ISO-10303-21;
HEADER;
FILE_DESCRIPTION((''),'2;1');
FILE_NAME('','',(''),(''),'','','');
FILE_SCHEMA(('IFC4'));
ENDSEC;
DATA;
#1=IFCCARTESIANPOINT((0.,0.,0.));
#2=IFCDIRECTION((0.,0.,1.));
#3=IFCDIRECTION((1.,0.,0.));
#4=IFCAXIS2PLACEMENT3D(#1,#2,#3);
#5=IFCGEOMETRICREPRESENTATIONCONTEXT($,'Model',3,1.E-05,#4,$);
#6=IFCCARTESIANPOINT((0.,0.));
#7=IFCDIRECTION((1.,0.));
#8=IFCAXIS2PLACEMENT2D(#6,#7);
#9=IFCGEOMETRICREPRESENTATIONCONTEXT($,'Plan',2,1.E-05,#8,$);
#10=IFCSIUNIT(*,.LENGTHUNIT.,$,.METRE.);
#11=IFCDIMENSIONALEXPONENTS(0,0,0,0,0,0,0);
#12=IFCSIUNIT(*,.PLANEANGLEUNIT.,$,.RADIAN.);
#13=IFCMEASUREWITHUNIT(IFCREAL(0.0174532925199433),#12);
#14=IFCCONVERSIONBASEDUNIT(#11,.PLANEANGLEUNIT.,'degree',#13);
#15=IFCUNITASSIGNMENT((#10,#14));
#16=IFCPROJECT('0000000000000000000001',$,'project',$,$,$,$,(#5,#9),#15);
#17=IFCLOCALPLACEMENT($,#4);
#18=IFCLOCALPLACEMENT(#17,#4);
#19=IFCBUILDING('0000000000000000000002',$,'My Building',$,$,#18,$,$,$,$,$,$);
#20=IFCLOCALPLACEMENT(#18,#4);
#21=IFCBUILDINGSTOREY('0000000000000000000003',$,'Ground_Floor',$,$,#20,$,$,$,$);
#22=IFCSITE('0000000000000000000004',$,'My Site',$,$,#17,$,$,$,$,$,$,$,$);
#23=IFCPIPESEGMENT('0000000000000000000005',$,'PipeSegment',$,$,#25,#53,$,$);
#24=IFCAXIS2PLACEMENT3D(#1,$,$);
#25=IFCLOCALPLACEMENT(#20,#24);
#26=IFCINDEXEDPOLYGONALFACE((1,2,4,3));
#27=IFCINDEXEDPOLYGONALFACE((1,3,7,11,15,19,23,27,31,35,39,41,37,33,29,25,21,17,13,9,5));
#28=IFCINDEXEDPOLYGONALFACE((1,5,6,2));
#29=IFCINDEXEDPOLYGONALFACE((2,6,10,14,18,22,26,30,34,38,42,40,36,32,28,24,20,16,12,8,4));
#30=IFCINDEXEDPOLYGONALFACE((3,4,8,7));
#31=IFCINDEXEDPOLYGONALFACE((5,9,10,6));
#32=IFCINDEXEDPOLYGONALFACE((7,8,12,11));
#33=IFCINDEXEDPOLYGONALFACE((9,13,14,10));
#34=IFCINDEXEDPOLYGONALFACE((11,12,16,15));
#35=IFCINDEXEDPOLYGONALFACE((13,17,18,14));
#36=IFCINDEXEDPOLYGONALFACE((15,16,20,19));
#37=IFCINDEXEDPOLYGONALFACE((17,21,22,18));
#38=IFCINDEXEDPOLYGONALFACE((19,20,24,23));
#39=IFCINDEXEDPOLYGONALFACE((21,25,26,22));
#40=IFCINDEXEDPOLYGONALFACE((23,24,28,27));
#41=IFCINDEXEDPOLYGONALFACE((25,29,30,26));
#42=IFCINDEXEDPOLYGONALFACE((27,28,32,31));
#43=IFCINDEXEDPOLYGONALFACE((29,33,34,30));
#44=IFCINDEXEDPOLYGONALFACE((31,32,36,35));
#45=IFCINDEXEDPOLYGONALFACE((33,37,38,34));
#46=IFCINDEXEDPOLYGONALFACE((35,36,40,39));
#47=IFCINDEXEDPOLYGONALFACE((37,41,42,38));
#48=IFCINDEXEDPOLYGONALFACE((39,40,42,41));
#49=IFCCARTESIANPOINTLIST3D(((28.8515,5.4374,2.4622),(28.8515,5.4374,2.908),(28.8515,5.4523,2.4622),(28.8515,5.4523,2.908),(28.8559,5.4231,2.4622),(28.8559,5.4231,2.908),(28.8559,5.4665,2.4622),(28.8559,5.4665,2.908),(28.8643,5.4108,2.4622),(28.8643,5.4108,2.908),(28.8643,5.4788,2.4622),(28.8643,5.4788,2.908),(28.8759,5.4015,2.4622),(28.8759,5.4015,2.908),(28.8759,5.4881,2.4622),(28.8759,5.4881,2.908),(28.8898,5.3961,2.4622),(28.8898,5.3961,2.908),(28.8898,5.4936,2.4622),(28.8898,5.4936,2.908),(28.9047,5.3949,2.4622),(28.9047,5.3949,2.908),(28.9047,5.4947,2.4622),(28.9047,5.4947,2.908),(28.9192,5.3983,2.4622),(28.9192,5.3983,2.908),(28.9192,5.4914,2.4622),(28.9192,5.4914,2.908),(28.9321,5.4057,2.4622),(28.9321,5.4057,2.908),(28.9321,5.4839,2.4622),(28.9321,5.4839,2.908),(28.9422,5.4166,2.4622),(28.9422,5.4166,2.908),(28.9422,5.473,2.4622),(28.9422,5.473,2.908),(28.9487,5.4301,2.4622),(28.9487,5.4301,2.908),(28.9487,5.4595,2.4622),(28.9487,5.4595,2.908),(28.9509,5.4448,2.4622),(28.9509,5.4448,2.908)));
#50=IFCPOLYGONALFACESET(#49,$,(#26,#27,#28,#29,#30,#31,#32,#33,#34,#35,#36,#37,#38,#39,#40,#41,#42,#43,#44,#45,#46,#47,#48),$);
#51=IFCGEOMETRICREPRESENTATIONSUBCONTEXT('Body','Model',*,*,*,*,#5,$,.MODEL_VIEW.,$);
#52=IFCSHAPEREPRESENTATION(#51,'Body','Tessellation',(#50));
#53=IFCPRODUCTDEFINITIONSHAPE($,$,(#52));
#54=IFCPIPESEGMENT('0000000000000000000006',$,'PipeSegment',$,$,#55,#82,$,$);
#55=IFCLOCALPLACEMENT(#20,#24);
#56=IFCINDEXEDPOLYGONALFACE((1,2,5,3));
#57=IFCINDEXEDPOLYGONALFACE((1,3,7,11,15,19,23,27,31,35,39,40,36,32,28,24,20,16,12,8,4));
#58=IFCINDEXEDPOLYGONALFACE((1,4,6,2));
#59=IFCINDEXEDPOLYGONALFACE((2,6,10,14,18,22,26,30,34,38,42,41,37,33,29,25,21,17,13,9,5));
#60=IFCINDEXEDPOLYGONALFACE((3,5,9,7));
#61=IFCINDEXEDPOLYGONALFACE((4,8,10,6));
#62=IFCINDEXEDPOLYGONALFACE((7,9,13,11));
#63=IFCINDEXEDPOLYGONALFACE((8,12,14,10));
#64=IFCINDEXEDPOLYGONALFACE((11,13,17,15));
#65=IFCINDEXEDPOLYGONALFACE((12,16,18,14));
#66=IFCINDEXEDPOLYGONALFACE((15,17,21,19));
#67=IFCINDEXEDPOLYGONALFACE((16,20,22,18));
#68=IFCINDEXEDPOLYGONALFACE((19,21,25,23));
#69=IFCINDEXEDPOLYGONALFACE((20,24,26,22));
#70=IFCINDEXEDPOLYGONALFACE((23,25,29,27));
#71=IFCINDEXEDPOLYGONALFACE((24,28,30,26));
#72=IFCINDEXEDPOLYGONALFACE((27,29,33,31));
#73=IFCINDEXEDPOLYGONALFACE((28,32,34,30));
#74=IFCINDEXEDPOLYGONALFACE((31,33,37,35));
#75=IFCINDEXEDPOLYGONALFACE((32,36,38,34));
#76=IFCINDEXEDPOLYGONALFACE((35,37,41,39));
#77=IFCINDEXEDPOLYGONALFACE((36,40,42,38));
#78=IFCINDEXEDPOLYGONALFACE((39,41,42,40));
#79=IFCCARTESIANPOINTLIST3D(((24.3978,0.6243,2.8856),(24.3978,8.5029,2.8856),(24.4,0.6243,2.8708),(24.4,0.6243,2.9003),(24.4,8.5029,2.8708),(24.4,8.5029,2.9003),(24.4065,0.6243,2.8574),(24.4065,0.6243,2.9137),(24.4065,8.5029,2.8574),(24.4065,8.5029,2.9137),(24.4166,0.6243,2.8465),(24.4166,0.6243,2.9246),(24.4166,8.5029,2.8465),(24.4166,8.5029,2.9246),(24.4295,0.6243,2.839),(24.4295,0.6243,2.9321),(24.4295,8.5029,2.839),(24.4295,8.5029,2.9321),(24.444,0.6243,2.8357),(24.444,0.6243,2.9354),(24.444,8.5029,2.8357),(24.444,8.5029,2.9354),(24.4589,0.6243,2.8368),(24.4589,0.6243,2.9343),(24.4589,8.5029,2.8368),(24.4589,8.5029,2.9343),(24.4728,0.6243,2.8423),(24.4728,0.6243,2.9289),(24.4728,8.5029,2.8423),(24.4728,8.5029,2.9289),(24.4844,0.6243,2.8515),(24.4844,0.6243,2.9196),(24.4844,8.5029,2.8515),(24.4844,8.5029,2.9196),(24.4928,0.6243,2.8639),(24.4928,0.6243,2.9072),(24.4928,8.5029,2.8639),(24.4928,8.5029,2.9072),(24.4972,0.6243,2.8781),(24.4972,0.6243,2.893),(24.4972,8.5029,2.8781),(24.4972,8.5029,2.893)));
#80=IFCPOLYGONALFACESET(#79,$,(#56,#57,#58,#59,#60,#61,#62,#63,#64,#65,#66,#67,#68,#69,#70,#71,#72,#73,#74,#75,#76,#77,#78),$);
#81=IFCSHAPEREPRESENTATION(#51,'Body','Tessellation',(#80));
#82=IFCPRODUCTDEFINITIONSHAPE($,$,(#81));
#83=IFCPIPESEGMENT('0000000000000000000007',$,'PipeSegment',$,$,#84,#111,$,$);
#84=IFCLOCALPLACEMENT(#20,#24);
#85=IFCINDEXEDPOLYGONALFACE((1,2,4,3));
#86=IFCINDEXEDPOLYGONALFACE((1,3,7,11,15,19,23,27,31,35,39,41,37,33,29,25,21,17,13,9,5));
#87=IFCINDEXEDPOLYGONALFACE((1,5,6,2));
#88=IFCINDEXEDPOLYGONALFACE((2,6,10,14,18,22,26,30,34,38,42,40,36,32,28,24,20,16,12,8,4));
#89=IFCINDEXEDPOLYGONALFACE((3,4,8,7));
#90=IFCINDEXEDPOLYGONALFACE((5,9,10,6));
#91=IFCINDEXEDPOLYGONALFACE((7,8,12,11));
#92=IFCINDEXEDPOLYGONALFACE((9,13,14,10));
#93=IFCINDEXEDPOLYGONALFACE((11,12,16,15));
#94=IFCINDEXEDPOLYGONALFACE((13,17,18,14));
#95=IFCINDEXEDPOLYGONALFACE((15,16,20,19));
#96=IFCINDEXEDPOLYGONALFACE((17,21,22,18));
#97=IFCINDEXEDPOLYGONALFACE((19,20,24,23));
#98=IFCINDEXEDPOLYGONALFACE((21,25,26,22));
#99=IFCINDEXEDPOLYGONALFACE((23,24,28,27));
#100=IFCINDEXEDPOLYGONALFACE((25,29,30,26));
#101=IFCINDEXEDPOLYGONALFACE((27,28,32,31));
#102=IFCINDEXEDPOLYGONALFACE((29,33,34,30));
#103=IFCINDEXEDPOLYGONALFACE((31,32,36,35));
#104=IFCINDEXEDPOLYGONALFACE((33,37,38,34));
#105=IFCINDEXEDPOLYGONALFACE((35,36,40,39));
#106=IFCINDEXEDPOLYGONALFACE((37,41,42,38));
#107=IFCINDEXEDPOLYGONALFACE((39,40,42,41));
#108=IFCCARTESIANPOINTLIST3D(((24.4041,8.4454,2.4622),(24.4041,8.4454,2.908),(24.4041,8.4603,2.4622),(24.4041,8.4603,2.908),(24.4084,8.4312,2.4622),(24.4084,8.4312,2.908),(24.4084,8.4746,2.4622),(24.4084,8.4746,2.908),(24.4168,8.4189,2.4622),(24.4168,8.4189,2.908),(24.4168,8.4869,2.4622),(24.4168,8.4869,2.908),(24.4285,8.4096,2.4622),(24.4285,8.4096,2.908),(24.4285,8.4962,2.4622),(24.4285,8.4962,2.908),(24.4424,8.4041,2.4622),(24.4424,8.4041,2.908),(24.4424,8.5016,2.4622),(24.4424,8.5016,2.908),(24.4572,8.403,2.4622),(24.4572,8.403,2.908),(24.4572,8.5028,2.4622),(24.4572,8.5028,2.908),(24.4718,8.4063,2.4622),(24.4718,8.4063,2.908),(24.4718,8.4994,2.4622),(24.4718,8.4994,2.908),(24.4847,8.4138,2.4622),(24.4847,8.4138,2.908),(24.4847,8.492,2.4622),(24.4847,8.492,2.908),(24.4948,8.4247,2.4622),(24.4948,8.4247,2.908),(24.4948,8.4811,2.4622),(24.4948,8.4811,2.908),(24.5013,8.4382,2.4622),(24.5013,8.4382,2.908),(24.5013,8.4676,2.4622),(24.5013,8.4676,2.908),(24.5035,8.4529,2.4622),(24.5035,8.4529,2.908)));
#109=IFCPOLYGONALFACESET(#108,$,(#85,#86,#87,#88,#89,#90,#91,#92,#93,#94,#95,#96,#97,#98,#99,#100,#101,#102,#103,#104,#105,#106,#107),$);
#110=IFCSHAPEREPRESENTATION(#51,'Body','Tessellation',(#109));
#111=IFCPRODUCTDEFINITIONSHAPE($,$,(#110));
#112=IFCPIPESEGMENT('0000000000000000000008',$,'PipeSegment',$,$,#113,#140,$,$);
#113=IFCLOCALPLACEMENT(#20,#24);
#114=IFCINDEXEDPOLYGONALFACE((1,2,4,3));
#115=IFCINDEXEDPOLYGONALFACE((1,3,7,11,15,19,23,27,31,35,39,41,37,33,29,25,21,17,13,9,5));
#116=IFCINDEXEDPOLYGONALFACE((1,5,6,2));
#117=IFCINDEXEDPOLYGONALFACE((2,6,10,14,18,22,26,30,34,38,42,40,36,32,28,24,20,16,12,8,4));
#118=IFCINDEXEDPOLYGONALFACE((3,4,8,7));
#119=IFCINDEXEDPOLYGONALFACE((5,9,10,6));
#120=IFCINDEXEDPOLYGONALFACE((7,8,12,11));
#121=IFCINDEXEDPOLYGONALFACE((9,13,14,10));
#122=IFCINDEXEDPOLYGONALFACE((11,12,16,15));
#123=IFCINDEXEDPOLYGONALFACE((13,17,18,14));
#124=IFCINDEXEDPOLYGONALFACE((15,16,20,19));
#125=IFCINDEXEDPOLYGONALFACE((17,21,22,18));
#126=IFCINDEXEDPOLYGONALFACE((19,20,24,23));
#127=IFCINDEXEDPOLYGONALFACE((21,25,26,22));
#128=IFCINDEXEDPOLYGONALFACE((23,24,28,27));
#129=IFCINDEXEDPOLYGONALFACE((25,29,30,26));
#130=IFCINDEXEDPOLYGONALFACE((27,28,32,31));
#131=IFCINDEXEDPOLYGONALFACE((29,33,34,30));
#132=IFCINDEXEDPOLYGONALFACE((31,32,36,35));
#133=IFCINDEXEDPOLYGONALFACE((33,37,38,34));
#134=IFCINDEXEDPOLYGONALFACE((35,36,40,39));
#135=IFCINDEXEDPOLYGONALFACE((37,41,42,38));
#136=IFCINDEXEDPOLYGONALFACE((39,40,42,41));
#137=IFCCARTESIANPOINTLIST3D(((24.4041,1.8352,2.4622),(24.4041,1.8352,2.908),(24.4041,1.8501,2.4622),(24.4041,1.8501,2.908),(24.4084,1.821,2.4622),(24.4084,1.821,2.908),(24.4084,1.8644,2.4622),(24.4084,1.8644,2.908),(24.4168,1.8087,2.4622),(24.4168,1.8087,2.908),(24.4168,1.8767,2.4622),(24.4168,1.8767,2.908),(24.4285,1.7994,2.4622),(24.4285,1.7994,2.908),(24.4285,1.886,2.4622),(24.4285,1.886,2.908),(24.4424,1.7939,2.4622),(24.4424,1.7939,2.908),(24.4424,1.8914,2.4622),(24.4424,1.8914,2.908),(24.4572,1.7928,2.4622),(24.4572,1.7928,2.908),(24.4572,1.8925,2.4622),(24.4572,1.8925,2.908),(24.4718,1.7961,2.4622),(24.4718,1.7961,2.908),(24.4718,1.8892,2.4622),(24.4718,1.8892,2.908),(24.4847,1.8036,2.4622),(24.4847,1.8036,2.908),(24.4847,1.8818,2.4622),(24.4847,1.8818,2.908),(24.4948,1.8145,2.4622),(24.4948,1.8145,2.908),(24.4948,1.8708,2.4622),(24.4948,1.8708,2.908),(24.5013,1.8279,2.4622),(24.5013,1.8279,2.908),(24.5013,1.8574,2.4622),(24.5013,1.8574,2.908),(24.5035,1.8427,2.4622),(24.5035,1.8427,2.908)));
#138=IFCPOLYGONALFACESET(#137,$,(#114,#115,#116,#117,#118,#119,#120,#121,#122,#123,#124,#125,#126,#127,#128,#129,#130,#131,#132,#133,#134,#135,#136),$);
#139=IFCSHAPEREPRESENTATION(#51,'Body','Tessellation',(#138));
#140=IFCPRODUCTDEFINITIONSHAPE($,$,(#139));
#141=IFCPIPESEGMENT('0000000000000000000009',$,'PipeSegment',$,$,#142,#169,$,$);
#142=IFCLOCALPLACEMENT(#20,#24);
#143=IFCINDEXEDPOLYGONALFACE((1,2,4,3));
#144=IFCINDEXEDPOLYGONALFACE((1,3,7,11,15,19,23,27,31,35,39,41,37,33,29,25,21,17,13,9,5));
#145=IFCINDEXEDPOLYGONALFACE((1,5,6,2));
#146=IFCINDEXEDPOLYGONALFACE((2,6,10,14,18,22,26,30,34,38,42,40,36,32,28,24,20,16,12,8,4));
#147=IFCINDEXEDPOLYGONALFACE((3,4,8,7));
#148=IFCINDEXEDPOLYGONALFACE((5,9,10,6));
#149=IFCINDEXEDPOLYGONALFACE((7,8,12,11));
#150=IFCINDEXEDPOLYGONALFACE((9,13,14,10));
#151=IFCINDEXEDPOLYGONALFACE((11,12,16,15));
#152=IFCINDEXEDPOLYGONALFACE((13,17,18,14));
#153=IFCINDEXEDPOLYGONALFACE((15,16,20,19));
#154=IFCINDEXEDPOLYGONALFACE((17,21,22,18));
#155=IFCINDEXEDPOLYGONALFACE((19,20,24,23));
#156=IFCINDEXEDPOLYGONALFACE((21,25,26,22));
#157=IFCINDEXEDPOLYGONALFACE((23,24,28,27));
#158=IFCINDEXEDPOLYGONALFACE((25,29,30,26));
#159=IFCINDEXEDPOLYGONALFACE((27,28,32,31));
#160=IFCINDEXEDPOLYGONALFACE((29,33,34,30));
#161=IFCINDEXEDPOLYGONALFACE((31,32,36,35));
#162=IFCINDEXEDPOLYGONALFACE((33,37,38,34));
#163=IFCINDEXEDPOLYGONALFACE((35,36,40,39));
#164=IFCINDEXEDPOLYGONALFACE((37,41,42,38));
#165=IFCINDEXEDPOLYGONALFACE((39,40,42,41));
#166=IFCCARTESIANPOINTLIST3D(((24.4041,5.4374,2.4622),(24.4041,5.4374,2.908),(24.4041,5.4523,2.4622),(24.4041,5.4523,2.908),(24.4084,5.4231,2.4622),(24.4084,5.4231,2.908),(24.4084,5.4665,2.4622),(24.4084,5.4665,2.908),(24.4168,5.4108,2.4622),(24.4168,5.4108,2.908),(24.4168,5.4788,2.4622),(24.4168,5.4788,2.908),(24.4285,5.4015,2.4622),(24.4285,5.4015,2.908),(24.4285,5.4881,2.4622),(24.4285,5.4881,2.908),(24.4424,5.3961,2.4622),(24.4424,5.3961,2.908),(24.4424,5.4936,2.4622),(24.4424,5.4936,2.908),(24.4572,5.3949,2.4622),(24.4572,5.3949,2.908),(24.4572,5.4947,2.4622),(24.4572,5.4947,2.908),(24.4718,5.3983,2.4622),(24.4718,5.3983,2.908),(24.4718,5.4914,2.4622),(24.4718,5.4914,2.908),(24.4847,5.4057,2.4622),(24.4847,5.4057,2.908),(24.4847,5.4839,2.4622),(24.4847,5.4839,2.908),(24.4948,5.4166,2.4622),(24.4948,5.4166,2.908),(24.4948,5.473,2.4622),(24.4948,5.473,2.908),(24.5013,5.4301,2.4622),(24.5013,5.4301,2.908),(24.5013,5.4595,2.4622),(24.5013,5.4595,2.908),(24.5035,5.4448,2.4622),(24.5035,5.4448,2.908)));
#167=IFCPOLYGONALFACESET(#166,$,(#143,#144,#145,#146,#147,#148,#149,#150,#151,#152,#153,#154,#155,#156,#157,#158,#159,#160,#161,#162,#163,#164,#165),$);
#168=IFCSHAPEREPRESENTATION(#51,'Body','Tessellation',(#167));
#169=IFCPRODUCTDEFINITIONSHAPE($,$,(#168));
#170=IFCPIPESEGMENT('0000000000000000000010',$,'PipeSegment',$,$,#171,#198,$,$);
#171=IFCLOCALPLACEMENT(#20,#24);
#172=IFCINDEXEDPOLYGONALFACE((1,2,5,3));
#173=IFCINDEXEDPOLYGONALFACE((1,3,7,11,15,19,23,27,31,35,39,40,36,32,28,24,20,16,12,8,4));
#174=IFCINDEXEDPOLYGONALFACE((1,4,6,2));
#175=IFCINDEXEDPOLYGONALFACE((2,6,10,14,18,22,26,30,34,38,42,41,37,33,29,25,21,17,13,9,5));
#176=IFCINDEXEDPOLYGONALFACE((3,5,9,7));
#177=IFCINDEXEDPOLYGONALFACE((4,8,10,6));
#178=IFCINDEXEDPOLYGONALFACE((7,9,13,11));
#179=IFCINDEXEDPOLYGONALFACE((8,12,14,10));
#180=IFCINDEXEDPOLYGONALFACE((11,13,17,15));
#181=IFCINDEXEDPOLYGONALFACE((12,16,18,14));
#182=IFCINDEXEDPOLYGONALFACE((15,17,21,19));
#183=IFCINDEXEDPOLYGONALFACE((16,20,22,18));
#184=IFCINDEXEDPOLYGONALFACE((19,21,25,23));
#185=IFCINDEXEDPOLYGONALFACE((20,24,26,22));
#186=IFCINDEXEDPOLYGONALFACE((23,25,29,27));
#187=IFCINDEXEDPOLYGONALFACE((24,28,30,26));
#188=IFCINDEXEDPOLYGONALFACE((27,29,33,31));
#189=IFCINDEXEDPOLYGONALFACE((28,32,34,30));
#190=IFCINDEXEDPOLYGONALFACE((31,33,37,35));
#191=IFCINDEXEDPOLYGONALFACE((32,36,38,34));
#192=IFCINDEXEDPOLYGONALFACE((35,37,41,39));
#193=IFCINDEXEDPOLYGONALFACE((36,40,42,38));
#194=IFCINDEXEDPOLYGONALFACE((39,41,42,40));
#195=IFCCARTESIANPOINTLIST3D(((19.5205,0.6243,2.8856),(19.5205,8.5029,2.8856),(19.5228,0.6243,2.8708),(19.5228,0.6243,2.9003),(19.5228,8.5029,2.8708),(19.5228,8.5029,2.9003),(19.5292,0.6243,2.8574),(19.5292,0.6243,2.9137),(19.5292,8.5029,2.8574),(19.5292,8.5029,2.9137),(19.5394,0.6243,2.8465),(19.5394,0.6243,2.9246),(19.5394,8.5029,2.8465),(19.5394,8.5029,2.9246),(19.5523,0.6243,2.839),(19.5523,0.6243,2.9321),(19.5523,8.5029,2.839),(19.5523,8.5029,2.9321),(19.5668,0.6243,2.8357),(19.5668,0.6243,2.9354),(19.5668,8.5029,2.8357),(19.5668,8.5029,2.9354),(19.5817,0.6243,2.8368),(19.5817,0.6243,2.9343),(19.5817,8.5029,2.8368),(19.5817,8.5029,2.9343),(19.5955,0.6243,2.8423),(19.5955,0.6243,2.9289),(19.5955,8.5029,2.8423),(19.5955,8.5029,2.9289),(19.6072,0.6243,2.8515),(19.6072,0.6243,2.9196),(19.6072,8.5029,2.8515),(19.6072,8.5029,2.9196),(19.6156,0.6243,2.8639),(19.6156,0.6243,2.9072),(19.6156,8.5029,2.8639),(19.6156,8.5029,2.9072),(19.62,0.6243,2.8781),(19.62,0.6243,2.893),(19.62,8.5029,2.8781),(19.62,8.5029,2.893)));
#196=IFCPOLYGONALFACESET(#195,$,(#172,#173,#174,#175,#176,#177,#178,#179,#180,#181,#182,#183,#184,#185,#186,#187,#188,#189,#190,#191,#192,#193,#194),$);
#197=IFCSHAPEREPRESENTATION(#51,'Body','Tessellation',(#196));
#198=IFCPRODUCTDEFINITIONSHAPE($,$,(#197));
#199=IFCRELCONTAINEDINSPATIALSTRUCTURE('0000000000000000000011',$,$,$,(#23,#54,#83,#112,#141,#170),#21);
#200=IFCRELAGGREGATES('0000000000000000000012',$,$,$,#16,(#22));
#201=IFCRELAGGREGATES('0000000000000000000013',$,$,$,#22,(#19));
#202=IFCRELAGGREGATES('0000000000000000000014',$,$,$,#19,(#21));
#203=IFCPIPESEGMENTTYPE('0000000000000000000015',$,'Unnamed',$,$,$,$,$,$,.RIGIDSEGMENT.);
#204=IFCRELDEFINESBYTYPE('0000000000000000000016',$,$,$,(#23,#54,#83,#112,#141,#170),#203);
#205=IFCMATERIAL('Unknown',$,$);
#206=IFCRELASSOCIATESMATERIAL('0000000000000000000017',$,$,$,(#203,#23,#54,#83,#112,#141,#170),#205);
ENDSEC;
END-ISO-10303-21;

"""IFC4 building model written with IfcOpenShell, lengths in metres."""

from ifc_helpers import new_model, entity, si_unit, converted_unit, frame, origin_with_axes, origin_2d_with_axis, place, context, subcontext, project, spatial, circle, extrude, material, material_profile, profile_set, profile_usage, type_object, element, save


model = new_model("IFC4")

# Units and contexts
model_context = context("Model", 3, precision=1e-05, world=origin_with_axes())
plan_context = context("Plan", 2, precision=1e-05, world=origin_2d_with_axis())
body_context_1 = subcontext(model_context, "Body", "Model", "MODEL_VIEW")
ifc_project = project(units=[si_unit("LENGTHUNIT", "METRE"), converted_unit("PLANEANGLEUNIT", "degree", entity("IfcReal", 0.0174532925199433), si_unit("PLANEANGLEUNIT", "RADIAN"), dimensions=[0, 0, 0, 0, 0, 0, 0])], contexts=[model_context, plan_context])

# Site, building, storey
site_placement = place(None, origin_with_axes())
site = spatial("IfcSite", under=ifc_project, at=site_placement, Name="My Site")
building_placement = place(site_placement, origin_with_axes())
building = spatial("IfcBuilding", under=site, at=building_placement, Name="My Building")
storey_placement = place(building_placement, origin_with_axes())
storey = spatial("IfcBuildingStorey", under=building, at=storey_placement, Name="Ground_Floor")

# Shared definitions
ifc_material = material(Name="Unknown")

# Pipe segments
ifc_material_profile_1 = material_profile(ifc_material, circle(Radius=0.05))
ifc_profile_set_1 = profile_set([ifc_material_profile_1])
pipe_segment_type = type_object("IfcPipeSegmentType", Name="Unnamed", PredefinedType="RIGIDSEGMENT", material=ifc_profile_set_1)
ifc_profile_usage_1 = profile_usage(ifc_profile_set_1, cardinal=5)
pipe_segment_1_placement = place(storey_placement, frame((28.9009, 5.4448, 2.908), z_axis=(0.0, 0.0, -1.0), x_axis=(1.0, 0.0, 0.0)))
element("IfcPipeSegment", 1, at=pipe_segment_1_placement, inside=storey, type_object=pipe_segment_type, material=ifc_profile_usage_1, Name="PipeSegment", context=body_context_1, shape_type="SweptSolid", body=[
    extrude(circle(Radius=0.05), origin_with_axes(), (0.0, 0.0, 1.0), 0.4458),
])
ifc_profile_usage_2 = profile_usage(ifc_profile_set_1, cardinal=5)
pipe_segment_2_placement = place(storey_placement, frame((24.4478, 0.6243, 2.8856), z_axis=(0.0, 1.0, 0.0), x_axis=(-1.0, 0.0, 0.0)))
element("IfcPipeSegment", 2, at=pipe_segment_2_placement, inside=storey, type_object=pipe_segment_type, material=ifc_profile_usage_2, Name="PipeSegment", context=body_context_1, shape_type="SweptSolid", body=[
    extrude(circle(Radius=0.05), origin_with_axes(), (0.0, 0.0, 1.0), 7.8786),
])
ifc_profile_usage_3 = profile_usage(ifc_profile_set_1, cardinal=5)
pipe_segment_3_placement = place(storey_placement, frame((24.4535, 8.4529, 2.908), z_axis=(0.0, 0.0, -1.0), x_axis=(1.0, 0.0, 0.0)))
element("IfcPipeSegment", 3, at=pipe_segment_3_placement, inside=storey, type_object=pipe_segment_type, material=ifc_profile_usage_3, Name="PipeSegment", context=body_context_1, shape_type="SweptSolid", body=[
    extrude(circle(Radius=0.05), origin_with_axes(), (0.0, 0.0, 1.0), 0.4458),
])
ifc_profile_usage_4 = profile_usage(ifc_profile_set_1, cardinal=5)
pipe_segment_4_placement = place(storey_placement, frame((24.4535, 1.8427, 2.908), z_axis=(0.0, 0.0, -1.0), x_axis=(1.0, 0.0, 0.0)))
element("IfcPipeSegment", 4, at=pipe_segment_4_placement, inside=storey, type_object=pipe_segment_type, material=ifc_profile_usage_4, Name="PipeSegment", context=body_context_1, shape_type="SweptSolid", body=[
    extrude(circle(Radius=0.05), origin_with_axes(), (0.0, 0.0, 1.0), 0.4458),
])
ifc_profile_usage_5 = profile_usage(ifc_profile_set_1, cardinal=5)
pipe_segment_5_placement = place(storey_placement, frame((24.4535, 5.4448, 2.908), z_axis=(0.0, 0.0, -1.0), x_axis=(1.0, 0.0, 0.0)))
element("IfcPipeSegment", 5, at=pipe_segment_5_placement, inside=storey, type_object=pipe_segment_type, material=ifc_profile_usage_5, Name="PipeSegment", context=body_context_1, shape_type="SweptSolid", body=[
    extrude(circle(Radius=0.05), origin_with_axes(), (0.0, 0.0, 1.0), 0.4458),
])
ifc_profile_usage_6 = profile_usage(ifc_profile_set_1, cardinal=5)
pipe_segment_6_placement = place(storey_placement, frame((19.5705, 0.6243, 2.8856), z_axis=(0.0, 1.0, 0.0), x_axis=(-1.0, 0.0, 0.0)))
element("IfcPipeSegment", 6, at=pipe_segment_6_placement, inside=storey, type_object=pipe_segment_type, material=ifc_profile_usage_6, Name="PipeSegment", context=body_context_1, shape_type="SweptSolid", body=[
    extrude(circle(Radius=0.05), origin_with_axes(), (0.0, 0.0, 1.0), 7.8786),
])

save(model, "model.ifc")
